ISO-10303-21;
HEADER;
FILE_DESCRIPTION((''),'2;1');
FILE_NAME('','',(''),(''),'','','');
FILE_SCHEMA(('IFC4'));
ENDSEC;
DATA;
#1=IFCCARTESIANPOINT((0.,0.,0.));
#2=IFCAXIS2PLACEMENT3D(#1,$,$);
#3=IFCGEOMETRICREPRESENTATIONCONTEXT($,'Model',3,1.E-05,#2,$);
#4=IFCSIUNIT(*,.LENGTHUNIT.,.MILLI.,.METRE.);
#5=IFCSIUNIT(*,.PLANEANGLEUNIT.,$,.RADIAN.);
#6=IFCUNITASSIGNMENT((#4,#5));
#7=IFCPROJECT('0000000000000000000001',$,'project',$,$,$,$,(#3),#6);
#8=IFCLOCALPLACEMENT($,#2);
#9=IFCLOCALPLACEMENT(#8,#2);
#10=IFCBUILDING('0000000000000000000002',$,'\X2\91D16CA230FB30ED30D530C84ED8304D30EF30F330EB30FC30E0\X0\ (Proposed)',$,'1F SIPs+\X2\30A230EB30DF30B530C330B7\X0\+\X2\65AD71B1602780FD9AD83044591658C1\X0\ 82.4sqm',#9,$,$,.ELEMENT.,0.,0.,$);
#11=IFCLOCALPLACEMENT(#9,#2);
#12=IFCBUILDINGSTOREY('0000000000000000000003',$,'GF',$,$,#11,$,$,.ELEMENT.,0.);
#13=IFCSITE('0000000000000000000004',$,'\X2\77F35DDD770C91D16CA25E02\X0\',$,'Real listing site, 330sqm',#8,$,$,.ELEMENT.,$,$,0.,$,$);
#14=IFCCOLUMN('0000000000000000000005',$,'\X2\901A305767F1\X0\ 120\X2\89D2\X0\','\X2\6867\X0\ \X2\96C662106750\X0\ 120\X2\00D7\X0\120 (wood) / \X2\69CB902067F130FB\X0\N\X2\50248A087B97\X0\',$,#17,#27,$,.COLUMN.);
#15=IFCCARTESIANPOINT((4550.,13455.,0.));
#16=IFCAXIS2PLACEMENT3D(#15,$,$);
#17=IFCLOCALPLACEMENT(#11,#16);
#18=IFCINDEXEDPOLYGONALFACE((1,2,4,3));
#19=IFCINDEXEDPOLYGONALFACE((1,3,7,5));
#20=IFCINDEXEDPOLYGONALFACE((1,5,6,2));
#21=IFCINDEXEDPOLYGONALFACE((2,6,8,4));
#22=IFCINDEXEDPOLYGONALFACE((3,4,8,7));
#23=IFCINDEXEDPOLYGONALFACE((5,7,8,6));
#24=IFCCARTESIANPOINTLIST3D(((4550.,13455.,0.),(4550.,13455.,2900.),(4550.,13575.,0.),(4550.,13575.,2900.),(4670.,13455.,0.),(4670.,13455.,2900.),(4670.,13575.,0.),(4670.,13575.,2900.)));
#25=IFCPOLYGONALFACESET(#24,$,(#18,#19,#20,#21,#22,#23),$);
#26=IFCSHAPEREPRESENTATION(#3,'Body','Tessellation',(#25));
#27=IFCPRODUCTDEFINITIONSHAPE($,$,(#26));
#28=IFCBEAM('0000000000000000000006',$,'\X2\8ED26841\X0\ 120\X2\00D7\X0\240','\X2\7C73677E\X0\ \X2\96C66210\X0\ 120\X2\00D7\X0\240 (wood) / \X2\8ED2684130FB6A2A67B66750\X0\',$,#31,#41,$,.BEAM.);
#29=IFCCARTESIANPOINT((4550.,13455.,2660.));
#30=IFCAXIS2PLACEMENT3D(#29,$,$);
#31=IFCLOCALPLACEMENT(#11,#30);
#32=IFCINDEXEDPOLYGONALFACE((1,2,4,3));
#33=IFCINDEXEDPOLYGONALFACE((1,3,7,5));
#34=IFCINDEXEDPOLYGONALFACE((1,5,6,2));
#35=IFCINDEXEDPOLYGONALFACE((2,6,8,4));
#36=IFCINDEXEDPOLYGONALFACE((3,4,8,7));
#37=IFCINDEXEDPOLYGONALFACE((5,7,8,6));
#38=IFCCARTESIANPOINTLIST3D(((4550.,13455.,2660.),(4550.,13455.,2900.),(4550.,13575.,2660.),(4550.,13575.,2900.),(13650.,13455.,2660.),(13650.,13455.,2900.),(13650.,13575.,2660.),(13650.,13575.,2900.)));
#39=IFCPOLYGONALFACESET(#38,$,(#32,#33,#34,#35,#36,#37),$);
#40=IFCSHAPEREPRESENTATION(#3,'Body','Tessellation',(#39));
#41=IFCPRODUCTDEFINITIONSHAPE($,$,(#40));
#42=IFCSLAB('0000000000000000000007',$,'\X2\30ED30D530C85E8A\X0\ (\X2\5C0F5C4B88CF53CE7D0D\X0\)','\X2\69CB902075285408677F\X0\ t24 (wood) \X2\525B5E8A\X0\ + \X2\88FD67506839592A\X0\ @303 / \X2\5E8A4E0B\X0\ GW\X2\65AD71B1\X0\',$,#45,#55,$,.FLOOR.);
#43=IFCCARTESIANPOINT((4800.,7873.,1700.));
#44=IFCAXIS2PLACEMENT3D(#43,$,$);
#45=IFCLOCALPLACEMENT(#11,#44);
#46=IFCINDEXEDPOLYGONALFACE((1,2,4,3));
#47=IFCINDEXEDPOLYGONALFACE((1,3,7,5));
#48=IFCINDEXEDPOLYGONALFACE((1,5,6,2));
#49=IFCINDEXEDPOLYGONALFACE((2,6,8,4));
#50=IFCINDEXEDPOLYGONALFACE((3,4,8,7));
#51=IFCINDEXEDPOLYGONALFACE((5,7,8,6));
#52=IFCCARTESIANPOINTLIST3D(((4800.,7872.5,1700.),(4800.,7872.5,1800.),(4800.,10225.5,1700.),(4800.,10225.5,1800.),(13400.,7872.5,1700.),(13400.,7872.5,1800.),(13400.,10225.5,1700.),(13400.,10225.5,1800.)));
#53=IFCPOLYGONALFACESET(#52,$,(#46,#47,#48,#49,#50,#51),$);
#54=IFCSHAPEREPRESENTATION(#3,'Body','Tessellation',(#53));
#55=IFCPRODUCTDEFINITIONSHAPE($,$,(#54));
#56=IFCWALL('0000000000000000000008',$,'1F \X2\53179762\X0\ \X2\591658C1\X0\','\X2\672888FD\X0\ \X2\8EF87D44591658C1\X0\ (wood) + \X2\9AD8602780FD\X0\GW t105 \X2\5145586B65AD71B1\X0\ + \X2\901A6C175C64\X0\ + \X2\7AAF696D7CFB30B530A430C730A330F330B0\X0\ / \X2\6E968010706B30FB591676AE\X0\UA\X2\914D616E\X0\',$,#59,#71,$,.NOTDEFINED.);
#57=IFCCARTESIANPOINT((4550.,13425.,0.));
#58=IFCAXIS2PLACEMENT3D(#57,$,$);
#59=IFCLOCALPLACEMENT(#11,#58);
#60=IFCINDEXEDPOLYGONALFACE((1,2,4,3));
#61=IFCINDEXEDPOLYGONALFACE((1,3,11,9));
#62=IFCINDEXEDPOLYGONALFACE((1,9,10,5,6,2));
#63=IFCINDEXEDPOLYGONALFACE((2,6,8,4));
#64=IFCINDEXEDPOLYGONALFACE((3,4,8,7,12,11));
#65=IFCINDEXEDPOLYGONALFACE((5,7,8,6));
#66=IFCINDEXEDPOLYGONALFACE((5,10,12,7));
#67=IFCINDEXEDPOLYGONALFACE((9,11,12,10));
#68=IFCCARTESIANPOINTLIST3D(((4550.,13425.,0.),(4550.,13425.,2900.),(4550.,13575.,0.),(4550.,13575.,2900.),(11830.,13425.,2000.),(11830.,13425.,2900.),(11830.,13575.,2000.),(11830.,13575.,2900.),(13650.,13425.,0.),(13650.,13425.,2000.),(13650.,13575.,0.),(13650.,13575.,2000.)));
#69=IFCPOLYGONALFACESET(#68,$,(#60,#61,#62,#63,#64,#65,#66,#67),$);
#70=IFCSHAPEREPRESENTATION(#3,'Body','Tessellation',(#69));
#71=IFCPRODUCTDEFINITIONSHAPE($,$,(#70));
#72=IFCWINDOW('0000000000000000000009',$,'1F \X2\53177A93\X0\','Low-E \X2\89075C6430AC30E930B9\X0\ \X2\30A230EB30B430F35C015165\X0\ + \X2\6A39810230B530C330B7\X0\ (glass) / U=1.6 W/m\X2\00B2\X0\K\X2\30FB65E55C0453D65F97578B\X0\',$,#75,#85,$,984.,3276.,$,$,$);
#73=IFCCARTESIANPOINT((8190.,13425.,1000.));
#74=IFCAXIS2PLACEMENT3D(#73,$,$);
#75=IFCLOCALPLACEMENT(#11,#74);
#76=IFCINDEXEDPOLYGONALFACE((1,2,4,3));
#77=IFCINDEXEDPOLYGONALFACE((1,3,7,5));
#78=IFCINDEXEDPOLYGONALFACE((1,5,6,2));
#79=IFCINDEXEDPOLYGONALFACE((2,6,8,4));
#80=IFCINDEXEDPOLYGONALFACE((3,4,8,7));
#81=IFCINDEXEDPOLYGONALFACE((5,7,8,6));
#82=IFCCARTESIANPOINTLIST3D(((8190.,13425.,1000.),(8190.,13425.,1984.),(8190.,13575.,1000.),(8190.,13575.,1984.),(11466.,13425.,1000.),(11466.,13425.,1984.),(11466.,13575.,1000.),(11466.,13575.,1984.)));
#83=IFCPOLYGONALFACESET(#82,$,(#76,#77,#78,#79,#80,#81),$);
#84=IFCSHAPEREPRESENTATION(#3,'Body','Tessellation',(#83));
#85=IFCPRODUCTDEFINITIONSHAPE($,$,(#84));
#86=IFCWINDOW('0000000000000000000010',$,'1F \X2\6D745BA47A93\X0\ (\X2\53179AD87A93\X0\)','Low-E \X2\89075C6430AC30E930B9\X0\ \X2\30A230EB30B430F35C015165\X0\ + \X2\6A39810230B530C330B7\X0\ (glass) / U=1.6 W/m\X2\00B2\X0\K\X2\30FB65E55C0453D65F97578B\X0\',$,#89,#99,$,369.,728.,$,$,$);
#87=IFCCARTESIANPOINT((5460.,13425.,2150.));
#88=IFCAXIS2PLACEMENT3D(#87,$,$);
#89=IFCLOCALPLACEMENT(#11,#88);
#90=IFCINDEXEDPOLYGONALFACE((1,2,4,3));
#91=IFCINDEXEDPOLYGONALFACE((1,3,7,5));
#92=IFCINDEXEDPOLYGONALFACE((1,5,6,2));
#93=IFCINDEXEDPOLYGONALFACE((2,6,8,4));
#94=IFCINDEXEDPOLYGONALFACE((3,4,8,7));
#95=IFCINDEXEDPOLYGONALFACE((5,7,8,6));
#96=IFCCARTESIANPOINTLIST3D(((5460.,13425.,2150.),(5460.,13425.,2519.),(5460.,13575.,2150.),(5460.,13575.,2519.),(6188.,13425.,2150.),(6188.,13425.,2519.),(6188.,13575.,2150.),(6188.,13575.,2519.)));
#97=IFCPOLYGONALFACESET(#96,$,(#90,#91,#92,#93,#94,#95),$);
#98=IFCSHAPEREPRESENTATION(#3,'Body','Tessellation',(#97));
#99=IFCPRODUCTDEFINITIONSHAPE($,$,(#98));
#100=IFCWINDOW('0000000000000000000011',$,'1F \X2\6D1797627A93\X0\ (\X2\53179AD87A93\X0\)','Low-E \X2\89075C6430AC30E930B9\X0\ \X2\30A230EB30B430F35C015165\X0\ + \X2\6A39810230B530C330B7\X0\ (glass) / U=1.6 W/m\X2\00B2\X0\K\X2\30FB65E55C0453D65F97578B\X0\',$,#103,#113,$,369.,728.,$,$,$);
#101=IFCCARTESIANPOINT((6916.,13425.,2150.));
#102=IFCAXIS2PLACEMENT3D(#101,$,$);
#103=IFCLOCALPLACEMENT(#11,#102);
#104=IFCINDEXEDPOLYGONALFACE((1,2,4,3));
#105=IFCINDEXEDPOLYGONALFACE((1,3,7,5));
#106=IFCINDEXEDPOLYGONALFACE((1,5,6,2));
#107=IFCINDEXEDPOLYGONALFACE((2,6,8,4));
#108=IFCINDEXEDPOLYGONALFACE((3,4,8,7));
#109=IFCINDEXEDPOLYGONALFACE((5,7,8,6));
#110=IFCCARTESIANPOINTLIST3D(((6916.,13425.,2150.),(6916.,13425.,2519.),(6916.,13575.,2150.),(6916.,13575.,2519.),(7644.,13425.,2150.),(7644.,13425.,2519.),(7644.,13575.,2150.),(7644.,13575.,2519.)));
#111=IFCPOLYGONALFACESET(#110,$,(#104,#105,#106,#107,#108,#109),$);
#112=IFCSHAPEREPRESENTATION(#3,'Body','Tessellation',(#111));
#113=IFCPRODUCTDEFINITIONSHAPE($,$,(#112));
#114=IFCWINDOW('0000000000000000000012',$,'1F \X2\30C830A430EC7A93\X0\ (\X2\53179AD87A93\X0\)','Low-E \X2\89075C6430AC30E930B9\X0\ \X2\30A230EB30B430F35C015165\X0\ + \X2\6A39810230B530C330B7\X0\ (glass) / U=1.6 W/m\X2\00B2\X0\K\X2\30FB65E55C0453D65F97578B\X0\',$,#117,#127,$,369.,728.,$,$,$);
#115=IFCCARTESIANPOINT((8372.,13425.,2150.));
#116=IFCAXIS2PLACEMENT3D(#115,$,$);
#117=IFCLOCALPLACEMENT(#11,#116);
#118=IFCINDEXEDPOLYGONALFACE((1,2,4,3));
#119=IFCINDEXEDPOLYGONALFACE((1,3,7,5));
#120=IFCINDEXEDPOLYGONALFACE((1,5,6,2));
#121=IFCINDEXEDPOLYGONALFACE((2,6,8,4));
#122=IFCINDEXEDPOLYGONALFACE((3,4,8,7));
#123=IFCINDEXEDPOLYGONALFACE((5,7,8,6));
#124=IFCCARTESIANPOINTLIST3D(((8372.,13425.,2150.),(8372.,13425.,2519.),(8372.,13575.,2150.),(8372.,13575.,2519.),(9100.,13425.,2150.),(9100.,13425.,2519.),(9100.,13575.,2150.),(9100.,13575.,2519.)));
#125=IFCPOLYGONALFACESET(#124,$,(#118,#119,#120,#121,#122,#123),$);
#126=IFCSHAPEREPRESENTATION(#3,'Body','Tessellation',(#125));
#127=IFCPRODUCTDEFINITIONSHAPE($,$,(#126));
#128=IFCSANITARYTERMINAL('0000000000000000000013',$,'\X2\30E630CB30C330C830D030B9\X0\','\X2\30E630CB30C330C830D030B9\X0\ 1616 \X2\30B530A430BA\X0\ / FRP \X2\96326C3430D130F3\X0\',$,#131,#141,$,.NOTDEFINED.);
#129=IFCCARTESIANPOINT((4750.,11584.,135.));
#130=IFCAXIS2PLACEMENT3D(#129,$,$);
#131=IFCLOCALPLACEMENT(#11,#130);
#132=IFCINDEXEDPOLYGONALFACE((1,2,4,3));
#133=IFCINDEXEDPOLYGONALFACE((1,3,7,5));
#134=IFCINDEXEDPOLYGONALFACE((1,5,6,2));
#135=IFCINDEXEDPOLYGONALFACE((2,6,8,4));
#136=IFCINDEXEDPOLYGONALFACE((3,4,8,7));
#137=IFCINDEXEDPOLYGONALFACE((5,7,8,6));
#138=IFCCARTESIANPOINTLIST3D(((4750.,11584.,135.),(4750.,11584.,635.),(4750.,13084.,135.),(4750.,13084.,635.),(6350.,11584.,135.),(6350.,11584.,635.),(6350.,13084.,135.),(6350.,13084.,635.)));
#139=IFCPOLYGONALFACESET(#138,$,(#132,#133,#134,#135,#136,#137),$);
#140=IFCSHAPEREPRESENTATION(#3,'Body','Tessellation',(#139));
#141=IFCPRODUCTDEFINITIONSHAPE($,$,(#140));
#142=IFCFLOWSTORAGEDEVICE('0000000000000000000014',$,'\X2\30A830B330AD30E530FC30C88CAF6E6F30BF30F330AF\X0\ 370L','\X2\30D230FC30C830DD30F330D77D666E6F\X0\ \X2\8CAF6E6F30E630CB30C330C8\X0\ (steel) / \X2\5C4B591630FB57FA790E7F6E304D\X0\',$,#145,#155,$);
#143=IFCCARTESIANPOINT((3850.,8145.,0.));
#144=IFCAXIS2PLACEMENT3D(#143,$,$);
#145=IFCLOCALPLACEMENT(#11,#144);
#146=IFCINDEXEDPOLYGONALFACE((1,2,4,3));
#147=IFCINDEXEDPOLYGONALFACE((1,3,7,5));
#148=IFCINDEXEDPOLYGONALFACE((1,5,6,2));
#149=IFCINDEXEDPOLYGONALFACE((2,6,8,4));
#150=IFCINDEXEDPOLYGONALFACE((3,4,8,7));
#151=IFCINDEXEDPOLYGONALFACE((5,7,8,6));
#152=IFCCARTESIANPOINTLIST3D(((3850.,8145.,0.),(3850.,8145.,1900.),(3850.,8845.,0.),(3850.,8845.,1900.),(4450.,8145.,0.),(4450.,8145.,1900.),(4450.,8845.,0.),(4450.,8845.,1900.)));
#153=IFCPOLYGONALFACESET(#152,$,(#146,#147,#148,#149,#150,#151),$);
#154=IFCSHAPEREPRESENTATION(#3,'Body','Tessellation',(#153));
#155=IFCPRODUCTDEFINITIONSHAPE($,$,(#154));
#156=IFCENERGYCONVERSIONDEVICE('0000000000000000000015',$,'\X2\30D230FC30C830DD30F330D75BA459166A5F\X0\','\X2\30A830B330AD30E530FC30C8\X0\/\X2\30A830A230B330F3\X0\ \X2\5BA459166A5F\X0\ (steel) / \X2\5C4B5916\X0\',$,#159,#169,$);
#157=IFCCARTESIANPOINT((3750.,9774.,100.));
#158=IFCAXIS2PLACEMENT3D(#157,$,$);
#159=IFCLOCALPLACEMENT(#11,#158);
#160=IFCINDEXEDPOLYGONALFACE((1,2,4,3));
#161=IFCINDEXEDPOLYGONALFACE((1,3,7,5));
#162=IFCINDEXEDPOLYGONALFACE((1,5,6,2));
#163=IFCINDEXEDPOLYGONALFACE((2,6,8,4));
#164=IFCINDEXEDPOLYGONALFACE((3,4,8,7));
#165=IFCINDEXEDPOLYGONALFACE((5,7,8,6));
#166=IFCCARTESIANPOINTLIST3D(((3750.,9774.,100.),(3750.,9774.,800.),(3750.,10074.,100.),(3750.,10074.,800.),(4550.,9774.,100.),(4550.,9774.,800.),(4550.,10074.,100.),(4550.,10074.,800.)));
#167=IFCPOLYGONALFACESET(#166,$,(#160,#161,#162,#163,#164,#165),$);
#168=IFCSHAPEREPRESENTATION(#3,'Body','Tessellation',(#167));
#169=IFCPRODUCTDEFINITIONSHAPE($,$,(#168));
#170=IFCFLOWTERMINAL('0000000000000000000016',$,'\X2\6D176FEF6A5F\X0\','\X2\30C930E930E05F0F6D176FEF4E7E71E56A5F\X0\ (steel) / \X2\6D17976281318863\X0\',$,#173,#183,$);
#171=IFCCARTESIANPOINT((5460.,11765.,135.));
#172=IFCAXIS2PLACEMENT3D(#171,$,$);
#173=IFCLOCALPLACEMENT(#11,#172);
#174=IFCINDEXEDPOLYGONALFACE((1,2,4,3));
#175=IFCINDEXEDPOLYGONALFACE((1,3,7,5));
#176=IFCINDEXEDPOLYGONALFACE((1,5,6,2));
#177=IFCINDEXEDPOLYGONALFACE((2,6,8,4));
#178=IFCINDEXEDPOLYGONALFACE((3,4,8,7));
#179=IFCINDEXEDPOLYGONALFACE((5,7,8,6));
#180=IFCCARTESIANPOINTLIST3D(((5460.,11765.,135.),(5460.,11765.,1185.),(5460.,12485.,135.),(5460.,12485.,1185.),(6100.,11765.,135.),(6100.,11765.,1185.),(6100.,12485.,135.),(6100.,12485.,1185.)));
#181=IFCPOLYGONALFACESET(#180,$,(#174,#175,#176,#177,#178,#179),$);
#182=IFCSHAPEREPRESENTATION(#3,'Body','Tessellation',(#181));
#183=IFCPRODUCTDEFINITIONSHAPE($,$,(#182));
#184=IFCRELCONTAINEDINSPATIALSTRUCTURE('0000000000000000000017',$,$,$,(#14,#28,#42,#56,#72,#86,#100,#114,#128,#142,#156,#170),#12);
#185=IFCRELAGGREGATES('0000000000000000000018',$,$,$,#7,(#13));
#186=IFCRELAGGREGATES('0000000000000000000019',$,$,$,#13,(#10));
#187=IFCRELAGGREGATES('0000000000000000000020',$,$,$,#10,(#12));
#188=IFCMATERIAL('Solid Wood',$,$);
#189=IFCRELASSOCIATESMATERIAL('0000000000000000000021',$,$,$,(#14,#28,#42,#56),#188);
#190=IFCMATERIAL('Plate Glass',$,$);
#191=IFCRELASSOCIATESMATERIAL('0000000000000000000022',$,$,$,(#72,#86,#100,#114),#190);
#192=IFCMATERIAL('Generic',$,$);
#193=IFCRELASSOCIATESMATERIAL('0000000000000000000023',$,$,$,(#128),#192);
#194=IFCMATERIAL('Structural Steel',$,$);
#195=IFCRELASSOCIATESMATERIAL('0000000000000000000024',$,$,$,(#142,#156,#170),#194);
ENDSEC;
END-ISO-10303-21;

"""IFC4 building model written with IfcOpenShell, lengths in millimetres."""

from ifc_helpers import new_model, si_unit, frame, frame_2d, origin, place, context, project, spatial, rectangle, extrude, material, element, fill, save


model = new_model("IFC4")

# Units and contexts
model_context = context("Model", 3, precision=1e-05, world=origin())
ifc_project = project(units=[si_unit("LENGTHUNIT", "METRE", prefix="MILLI"), si_unit("PLANEANGLEUNIT", "RADIAN")], contexts=[model_context])

# Site, building, storey
site_placement = place(None, origin())
site = spatial("IfcSite", under=ifc_project, at=site_placement, Name="石川県金沢市", ObjectType="Real listing site, 330sqm", CompositionType="ELEMENT", RefElevation=0.0)
building_placement = place(site_placement, origin())
building = spatial("IfcBuilding", under=site, at=building_placement, Name="金沢・ロフト付きワンルーム (Proposed)", ObjectType="1F SIPs+アルミサッシ+断熱性能高い外壁 82.4sqm", CompositionType="ELEMENT", ElevationOfRefHeight=0.0, ElevationOfTerrain=0.0)
storey_placement = place(building_placement, origin())
storey = spatial("IfcBuildingStorey", under=building, at=storey_placement, Name="GF", CompositionType="ELEMENT", Elevation=0.0)

# Column
ifc_material_1 = material(Name="Solid Wood")
column_1_placement = place(storey_placement, frame((4550.0, 13455.0, 0.0)))
element("IfcColumn", 1, at=column_1_placement, inside=storey, material=ifc_material_1, Name="通し柱 120角", Description="桧 集成材 120×120 (wood) / 構造柱・N値計算", PredefinedType="COLUMN", context=model_context, shape_type="SweptSolid", body=[
    extrude(rectangle(XDim=120.0, YDim=120.0, at=frame_2d((60.0, 60.0))), frame((4550.0, 13455.0, 0.0)), (0.0, 0.0, 1.0), 2900.0),
])

# Beam
beam_1_placement = place(storey_placement, frame((4550.0, 13455.0, 2660.0)))
element("IfcBeam", 2, at=beam_1_placement, inside=storey, material=ifc_material_1, Name="軒桁 120×240", Description="米松 集成 120×240 (wood) / 軒桁・横架材", PredefinedType="BEAM", context=model_context, shape_type="SweptSolid", body=[
    extrude(rectangle(XDim=9100.0, YDim=120.0, at=frame_2d((4550.0, 60.0))), frame((4550.0, 13455.0, 2660.0)), (0.0, 0.0, 1.0), 240.0),
])

# Slab
slab_placement = place(storey_placement, frame((4800.0, 7873.0, 1700.0)))
element("IfcSlab", 3, at=slab_placement, inside=storey, material=ifc_material_1, Name="ロフト床 (小屋裏収納)", Description="構造用合板 t24 (wood) 剛床 + 製材根太 @303 / 床下 GW断熱", PredefinedType="FLOOR", context=model_context, shape_type="SweptSolid", body=[
    extrude(rectangle(XDim=8600.0, YDim=2353.0, at=frame_2d((4300.0, 1176.0))), frame((4800.0, 7873.0, 1700.0)), (0.0, 0.0, 1.0), 100.0),
])

# Wall, openings, windows
wall_1_placement = place(storey_placement, frame((4550.0, 13425.0, 0.0)))
wall_1 = element("IfcWall", 4, at=wall_1_placement, inside=storey, material=ifc_material_1, Name="1F 北面 外壁", Description="木製 軸組外壁 (wood) + 高性能GW t105 充填断熱 + 通気層 + 窯業系サイディング / 準耐火・外皮UA配慮", PredefinedType="NOTDEFINED", context=model_context, shape_type="SweptSolid", body=[
    extrude(rectangle(XDim=9100.0, YDim=150.0, at=frame_2d((4550.0, 75.0))), frame((4550.0, 13425.0, 0.0)), (0.0, 0.0, 1.0), 2900.0),
])
opening_1_placement = place(storey_placement, frame((8190.0, 13425.0, 1000.0)))
opening_1 = element("IfcOpeningElement", 5, at=opening_1_placement, cuts=wall_1, PredefinedType="NOTDEFINED", context=model_context, shape_type="SweptSolid", body=[
    extrude(rectangle(XDim=3276.0, YDim=150.0, at=frame_2d((1638.0, 75.0))), frame((8190.0, 13425.0, 1000.0)), (0.0, 0.0, 1.0), 984.0),
])
opening_2_placement = place(storey_placement, frame((5460.0, 13425.0, 2150.0)))
opening_2 = element("IfcOpeningElement", 6, at=opening_2_placement, cuts=wall_1, PredefinedType="NOTDEFINED", context=model_context, shape_type="SweptSolid", body=[
    extrude(rectangle(XDim=728.0, YDim=150.0, at=frame_2d((364.0, 75.0))), frame((5460.0, 13425.0, 2150.0)), (0.0, 0.0, 1.0), 369.0),
])
opening_3_placement = place(storey_placement, frame((6916.0, 13425.0, 2150.0)))
opening_3 = element("IfcOpeningElement", 7, at=opening_3_placement, cuts=wall_1, PredefinedType="NOTDEFINED", context=model_context, shape_type="SweptSolid", body=[
    extrude(rectangle(XDim=728.0, YDim=150.0, at=frame_2d((364.0, 75.0))), frame((6916.0, 13425.0, 2150.0)), (0.0, 0.0, 1.0), 369.0),
])
opening_4_placement = place(storey_placement, frame((8372.0, 13425.0, 2150.0)))
opening_4 = element("IfcOpeningElement", 8, at=opening_4_placement, cuts=wall_1, PredefinedType="NOTDEFINED", context=model_context, shape_type="SweptSolid", body=[
    extrude(rectangle(XDim=728.0, YDim=150.0, at=frame_2d((364.0, 75.0))), frame((8372.0, 13425.0, 2150.0)), (0.0, 0.0, 1.0), 369.0),
])
ifc_material_2 = material(Name="Plate Glass")
window_1_placement = place(storey_placement, frame((8190.0, 13425.0, 1000.0)))
window_1 = element("IfcWindow", 9, at=window_1_placement, inside=storey, material=ifc_material_2, Name="1F 北窓", Description="Low-E 複層ガラス アルゴン封入 + 樹脂サッシ (glass) / U=1.6 W/m²K・日射取得型", OverallHeight=984.0, OverallWidth=3276.0, context=model_context, shape_type="SweptSolid", body=[
    extrude(rectangle(XDim=3276.0, YDim=150.0, at=frame_2d((1638.0, 75.0))), frame((8190.0, 13425.0, 1000.0)), (0.0, 0.0, 1.0), 984.0),
])
fill(opening_1, window_1)
window_2_placement = place(storey_placement, frame((5460.0, 13425.0, 2150.0)))
window_2 = element("IfcWindow", 10, at=window_2_placement, inside=storey, material=ifc_material_2, Name="1F 浴室窓 (北高窓)", Description="Low-E 複層ガラス アルゴン封入 + 樹脂サッシ (glass) / U=1.6 W/m²K・日射取得型", OverallHeight=369.0, OverallWidth=728.0, context=model_context, shape_type="SweptSolid", body=[
    extrude(rectangle(XDim=728.0, YDim=150.0, at=frame_2d((364.0, 75.0))), frame((5460.0, 13425.0, 2150.0)), (0.0, 0.0, 1.0), 369.0),
])
fill(opening_2, window_2)
window_3_placement = place(storey_placement, frame((6916.0, 13425.0, 2150.0)))
window_3 = element("IfcWindow", 11, at=window_3_placement, inside=storey, material=ifc_material_2, Name="1F 洗面窓 (北高窓)", Description="Low-E 複層ガラス アルゴン封入 + 樹脂サッシ (glass) / U=1.6 W/m²K・日射取得型", OverallHeight=369.0, OverallWidth=728.0, context=model_context, shape_type="SweptSolid", body=[
    extrude(rectangle(XDim=728.0, YDim=150.0, at=frame_2d((364.0, 75.0))), frame((6916.0, 13425.0, 2150.0)), (0.0, 0.0, 1.0), 369.0),
])
fill(opening_3, window_3)
window_4_placement = place(storey_placement, frame((8372.0, 13425.0, 2150.0)))
window_4 = element("IfcWindow", 12, at=window_4_placement, inside=storey, material=ifc_material_2, Name="1F トイレ窓 (北高窓)", Description="Low-E 複層ガラス アルゴン封入 + 樹脂サッシ (glass) / U=1.6 W/m²K・日射取得型", OverallHeight=369.0, OverallWidth=728.0, context=model_context, shape_type="SweptSolid", body=[
    extrude(rectangle(XDim=728.0, YDim=150.0, at=frame_2d((364.0, 75.0))), frame((8372.0, 13425.0, 2150.0)), (0.0, 0.0, 1.0), 369.0),
])
fill(opening_4, window_4)

# Sanitary terminal
ifc_material_3 = material(Name="Generic")
sanitary_terminal_placement = place(storey_placement, frame((4750.0, 11584.0, 135.0)))
element("IfcSanitaryTerminal", 13, at=sanitary_terminal_placement, inside=storey, material=ifc_material_3, Name="ユニットバス", Description="ユニットバス 1616 サイズ / FRP 防水パン", PredefinedType="NOTDEFINED", context=model_context, shape_type="SweptSolid", body=[
    extrude(rectangle(XDim=1600.0, YDim=1500.0, at=frame_2d((800.0, 750.0))), frame((4750.0, 11584.0, 135.0)), (0.0, 0.0, 1.0), 500.0),
])

# Flow storage device
ifc_material_4 = material(Name="Structural Steel")
flow_storage_device_placement = place(storey_placement, frame((3850.0, 8145.0, 0.0)))
element("IfcFlowStorageDevice", 14, at=flow_storage_device_placement, inside=storey, material=ifc_material_4, Name="エコキュート貯湯タンク 370L", Description="ヒートポンプ給湯 貯湯ユニット (steel) / 屋外・基礎置き", context=model_context, shape_type="SweptSolid", body=[
    extrude(rectangle(XDim=600.0, YDim=700.0, at=frame_2d((300.0, 350.0))), frame((3850.0, 8145.0, 0.0)), (0.0, 0.0, 1.0), 1900.0),
])

# Energy conversion device
energy_conversion_device_placement = place(storey_placement, frame((3750.0, 9774.0, 100.0)))
element("IfcEnergyConversionDevice", 15, at=energy_conversion_device_placement, inside=storey, material=ifc_material_4, Name="ヒートポンプ室外機", Description="エコキュート/エアコン 室外機 (steel) / 屋外", context=model_context, shape_type="SweptSolid", body=[
    extrude(rectangle(XDim=800.0, YDim=300.0, at=frame_2d((400.0, 150.0))), frame((3750.0, 9774.0, 100.0)), (0.0, 0.0, 1.0), 700.0),
])

# Flow terminal
flow_terminal_placement = place(storey_placement, frame((5460.0, 11765.0, 135.0)))
element("IfcFlowTerminal", 16, at=flow_terminal_placement, inside=storey, material=ifc_material_4, Name="洗濯機", Description="ドラム式洗濯乾燥機 (steel) / 洗面脱衣", context=model_context, shape_type="SweptSolid", body=[
    extrude(rectangle(XDim=640.0, YDim=720.0, at=frame_2d((320.0, 360.0))), frame((5460.0, 11765.0, 135.0)), (0.0, 0.0, 1.0), 1050.0),
])

save(model, "model.ifc")
